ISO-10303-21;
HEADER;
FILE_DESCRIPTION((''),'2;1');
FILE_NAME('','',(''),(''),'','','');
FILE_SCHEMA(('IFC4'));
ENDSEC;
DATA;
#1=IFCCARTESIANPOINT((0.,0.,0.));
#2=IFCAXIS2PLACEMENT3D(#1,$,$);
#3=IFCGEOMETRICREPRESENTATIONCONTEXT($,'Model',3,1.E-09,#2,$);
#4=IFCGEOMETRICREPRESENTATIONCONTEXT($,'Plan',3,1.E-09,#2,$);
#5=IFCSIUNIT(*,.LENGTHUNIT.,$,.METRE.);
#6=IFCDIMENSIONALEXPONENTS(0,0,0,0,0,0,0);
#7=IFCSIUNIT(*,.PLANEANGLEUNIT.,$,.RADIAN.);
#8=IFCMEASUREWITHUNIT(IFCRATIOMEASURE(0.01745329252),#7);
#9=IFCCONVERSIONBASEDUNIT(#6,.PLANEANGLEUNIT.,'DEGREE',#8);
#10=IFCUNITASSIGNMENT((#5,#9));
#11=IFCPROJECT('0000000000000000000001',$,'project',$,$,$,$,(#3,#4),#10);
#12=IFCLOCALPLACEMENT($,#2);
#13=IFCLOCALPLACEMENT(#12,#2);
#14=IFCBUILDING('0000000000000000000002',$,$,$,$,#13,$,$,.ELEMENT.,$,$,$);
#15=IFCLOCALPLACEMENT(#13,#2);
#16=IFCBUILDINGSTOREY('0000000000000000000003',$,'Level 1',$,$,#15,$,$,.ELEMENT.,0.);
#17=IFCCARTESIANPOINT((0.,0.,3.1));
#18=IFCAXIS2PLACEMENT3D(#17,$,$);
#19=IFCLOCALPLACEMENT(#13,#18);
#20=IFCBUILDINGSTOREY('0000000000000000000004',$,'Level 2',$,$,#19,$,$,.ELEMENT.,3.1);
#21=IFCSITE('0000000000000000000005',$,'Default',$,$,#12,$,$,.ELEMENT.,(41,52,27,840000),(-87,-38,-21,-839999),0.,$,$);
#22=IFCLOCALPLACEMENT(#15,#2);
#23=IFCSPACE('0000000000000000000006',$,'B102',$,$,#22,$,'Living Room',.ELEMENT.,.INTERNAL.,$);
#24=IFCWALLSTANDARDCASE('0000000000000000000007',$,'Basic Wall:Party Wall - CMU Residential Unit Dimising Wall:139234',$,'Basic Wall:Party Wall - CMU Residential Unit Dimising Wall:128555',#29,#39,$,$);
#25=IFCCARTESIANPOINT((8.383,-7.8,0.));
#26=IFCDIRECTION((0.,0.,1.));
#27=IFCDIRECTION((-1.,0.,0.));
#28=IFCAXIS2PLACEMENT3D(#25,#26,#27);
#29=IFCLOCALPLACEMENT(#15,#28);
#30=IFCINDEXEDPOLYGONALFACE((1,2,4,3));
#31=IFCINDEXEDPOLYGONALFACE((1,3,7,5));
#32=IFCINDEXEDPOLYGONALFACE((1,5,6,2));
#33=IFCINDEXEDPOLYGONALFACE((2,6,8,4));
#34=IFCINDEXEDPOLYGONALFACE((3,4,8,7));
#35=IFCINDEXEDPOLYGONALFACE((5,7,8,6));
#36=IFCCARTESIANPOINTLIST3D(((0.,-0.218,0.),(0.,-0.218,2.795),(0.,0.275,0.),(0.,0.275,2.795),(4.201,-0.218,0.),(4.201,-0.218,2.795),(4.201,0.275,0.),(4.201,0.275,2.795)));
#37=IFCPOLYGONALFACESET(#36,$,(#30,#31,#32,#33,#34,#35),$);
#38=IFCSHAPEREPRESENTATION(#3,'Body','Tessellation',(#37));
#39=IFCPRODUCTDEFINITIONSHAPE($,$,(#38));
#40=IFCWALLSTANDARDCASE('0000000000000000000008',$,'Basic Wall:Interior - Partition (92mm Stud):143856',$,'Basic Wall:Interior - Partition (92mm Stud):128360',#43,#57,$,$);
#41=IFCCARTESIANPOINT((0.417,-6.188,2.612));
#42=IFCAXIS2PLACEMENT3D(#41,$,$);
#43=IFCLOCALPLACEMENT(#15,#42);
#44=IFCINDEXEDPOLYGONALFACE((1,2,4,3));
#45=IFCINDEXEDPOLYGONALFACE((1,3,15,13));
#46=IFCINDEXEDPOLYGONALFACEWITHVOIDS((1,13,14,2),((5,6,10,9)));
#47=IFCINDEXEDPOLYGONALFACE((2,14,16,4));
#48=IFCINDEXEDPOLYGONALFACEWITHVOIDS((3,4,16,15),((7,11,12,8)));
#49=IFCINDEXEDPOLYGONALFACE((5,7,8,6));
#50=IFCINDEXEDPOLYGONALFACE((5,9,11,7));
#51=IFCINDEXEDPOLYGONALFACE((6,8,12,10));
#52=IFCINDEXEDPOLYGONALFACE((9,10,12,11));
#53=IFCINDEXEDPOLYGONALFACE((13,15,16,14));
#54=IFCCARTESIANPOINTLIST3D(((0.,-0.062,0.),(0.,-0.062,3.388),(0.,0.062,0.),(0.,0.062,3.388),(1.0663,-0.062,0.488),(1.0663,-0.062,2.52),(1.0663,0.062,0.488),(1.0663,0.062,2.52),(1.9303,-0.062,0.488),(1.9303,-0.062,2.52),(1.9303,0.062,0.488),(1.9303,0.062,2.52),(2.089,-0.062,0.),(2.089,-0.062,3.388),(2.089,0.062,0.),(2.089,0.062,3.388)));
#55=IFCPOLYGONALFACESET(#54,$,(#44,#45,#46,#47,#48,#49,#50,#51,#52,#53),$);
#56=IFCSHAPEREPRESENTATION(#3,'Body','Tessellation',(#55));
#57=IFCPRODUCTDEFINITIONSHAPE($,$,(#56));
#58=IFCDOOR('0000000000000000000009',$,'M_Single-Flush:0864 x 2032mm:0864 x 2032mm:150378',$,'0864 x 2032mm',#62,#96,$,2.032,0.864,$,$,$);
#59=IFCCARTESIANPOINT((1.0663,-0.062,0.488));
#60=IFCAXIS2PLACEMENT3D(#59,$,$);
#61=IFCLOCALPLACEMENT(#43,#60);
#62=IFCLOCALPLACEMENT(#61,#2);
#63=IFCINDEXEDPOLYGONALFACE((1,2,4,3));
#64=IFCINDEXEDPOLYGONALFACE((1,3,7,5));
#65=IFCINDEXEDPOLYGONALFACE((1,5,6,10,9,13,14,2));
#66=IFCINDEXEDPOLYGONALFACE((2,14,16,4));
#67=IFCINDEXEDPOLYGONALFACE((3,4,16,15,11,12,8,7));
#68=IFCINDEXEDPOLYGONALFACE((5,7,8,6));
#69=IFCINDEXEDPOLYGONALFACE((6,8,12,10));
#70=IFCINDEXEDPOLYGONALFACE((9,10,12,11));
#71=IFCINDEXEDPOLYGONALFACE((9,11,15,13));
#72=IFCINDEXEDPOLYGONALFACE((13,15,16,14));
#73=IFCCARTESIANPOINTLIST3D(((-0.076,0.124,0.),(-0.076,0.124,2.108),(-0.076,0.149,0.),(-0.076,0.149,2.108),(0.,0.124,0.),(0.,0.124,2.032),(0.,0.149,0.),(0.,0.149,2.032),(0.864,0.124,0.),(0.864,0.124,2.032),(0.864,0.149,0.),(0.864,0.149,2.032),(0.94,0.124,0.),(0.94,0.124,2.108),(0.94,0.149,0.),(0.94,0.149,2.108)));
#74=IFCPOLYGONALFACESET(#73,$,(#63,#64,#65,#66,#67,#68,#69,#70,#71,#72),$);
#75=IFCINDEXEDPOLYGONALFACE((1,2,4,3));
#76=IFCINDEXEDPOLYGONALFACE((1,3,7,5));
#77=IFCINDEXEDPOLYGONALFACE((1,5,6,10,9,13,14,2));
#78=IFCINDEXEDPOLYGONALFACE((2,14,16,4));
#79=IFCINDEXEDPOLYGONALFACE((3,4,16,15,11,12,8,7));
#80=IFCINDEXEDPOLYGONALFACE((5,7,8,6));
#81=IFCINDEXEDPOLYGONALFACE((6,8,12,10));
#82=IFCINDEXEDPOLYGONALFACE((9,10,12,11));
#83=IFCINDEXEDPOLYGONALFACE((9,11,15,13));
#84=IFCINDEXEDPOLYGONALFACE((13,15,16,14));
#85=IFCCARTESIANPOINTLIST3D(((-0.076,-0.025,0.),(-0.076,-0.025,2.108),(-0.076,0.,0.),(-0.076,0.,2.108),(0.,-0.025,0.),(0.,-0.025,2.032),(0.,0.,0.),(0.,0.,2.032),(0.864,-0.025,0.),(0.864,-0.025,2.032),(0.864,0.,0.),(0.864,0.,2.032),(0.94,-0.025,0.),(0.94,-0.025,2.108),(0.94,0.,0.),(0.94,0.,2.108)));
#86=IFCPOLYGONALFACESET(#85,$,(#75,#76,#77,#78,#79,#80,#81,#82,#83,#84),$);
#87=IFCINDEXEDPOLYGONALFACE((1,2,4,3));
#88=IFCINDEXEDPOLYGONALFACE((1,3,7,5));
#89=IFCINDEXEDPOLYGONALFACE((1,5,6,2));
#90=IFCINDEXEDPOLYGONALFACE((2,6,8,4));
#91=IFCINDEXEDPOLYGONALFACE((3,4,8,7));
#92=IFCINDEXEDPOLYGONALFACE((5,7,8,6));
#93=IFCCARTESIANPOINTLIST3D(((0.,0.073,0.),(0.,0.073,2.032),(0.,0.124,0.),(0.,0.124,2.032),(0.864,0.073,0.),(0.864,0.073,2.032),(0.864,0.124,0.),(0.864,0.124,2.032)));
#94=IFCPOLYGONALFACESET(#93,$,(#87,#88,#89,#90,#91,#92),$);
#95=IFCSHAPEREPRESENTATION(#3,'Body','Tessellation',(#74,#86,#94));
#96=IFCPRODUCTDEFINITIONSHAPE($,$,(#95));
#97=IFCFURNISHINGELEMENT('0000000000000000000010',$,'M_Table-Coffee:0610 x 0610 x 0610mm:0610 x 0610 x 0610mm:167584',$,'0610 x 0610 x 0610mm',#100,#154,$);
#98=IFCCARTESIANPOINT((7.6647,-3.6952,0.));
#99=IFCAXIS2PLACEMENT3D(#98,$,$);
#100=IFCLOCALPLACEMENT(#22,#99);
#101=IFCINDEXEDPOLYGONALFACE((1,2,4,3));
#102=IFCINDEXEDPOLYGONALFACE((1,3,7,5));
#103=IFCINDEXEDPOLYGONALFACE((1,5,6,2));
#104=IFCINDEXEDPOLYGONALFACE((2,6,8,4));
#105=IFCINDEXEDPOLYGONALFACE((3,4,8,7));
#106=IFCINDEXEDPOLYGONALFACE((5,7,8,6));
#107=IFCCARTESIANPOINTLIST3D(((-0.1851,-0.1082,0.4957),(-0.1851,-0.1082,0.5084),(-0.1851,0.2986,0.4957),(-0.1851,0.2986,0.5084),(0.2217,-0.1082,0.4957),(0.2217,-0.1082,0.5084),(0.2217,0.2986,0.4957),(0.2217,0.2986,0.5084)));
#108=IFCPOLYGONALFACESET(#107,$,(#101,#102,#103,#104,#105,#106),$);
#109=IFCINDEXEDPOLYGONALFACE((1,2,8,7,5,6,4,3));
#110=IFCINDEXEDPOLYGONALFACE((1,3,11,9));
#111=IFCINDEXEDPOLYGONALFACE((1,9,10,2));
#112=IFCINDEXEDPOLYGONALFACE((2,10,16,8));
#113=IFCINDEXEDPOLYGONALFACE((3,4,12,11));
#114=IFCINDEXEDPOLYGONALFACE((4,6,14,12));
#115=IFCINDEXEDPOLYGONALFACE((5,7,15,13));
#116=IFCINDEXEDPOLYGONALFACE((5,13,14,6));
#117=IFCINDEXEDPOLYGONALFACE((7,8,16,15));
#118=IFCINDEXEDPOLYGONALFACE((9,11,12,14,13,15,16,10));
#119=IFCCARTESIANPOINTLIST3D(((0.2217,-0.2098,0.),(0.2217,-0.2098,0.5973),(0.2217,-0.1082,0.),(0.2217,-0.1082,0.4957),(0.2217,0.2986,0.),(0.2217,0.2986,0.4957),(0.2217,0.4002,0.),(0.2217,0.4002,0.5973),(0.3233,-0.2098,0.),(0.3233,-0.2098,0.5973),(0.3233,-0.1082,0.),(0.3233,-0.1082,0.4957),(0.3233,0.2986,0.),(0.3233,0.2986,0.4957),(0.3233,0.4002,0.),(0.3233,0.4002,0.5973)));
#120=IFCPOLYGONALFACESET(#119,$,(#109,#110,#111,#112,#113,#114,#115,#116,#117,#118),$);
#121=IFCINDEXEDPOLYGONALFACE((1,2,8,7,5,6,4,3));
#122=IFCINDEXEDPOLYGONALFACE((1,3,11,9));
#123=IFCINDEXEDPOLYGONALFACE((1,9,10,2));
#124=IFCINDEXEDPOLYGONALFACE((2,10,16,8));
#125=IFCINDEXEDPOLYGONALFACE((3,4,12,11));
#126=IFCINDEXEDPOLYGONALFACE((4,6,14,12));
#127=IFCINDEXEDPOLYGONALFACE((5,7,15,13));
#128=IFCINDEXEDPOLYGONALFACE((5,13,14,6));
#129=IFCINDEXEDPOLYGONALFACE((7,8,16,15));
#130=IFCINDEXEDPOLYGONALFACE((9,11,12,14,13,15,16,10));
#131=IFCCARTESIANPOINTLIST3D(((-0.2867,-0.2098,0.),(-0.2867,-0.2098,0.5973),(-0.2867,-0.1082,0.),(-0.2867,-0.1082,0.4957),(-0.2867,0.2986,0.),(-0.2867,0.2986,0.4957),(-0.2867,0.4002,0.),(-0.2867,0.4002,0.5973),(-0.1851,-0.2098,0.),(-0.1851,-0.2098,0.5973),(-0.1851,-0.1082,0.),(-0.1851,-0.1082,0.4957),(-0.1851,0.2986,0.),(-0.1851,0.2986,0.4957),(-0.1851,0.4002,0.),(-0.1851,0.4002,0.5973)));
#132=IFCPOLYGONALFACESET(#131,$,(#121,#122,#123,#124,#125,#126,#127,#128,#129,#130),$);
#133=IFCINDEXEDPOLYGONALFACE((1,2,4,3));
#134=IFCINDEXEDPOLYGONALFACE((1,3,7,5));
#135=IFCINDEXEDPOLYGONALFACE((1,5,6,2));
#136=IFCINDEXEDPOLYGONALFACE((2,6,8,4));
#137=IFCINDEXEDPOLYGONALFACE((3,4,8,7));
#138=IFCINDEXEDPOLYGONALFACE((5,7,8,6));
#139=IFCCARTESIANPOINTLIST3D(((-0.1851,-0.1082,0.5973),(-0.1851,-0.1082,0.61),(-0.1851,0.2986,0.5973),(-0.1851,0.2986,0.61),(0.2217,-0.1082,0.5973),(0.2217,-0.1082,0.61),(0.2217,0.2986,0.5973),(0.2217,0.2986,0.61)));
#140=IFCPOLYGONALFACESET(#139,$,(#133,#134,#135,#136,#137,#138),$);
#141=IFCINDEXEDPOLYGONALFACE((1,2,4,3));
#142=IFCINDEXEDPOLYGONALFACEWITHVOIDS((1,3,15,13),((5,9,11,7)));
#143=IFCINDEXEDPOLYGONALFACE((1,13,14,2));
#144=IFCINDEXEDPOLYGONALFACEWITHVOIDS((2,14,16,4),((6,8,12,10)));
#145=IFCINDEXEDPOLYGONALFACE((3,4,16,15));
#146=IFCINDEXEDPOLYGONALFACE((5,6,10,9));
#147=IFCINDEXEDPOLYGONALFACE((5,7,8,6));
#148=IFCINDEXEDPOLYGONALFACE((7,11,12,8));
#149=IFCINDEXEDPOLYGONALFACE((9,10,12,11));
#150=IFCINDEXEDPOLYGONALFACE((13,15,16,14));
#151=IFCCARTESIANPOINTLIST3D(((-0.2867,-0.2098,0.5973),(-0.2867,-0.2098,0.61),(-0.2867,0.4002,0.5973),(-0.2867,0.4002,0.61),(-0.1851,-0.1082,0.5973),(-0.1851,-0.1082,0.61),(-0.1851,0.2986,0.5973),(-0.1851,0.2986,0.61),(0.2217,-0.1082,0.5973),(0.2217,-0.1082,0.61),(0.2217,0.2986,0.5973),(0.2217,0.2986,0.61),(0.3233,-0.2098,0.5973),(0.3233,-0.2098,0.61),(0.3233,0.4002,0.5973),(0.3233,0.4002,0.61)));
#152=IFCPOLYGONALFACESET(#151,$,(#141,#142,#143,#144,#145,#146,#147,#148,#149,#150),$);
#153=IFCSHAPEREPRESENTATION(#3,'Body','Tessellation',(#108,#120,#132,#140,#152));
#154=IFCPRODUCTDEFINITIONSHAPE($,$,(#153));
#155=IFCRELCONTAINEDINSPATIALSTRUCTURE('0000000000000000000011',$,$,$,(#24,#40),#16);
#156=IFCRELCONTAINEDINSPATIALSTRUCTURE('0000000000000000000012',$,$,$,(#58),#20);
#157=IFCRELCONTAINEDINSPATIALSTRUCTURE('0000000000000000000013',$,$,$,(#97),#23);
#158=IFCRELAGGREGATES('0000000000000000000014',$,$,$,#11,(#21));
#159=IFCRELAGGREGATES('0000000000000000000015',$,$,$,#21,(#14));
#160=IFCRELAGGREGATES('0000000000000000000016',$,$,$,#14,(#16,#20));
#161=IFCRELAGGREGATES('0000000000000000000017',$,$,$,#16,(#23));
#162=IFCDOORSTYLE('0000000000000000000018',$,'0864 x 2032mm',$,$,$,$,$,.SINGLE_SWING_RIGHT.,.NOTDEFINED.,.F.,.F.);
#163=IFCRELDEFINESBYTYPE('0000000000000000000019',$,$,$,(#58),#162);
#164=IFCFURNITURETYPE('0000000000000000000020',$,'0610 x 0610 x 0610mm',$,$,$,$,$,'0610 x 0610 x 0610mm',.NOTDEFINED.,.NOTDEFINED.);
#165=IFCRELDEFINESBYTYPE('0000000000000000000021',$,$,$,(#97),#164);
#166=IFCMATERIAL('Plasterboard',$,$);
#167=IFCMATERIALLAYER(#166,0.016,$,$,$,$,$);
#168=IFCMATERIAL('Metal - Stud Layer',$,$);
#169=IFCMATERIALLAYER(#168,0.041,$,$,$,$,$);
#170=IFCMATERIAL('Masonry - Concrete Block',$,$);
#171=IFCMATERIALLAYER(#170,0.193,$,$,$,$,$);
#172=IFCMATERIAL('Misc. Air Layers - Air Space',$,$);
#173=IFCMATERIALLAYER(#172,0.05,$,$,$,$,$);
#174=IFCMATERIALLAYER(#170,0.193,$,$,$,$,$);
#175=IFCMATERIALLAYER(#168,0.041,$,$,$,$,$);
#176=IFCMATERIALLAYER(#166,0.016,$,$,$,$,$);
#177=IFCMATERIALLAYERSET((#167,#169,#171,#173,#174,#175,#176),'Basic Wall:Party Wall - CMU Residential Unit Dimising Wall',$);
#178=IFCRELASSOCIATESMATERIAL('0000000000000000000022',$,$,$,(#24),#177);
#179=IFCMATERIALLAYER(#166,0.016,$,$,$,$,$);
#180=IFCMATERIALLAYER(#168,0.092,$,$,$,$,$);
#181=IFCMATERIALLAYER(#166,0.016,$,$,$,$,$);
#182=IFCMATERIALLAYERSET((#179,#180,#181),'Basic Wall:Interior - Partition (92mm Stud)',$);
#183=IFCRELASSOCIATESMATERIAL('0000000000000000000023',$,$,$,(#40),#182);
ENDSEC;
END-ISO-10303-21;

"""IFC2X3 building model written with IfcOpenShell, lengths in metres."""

from ifc_helpers import new_model, entity, si_unit, converted_unit, frame, frame_2d, origin, origin_2d_with_axis, place, context, project, spatial, polyline, rectangle, outline, extrude, clip, bounded_halfspace, source, transform, mapped, material, layer, layer_set, layer_usage, type_object, type_shapes, element, fill, save


model = new_model("IFC2X3")

# Units and contexts
model_context = context("Model", 3, precision=1e-09, world=origin())
plan_context = context("Plan", 3, precision=1e-09, world=origin())
ifc_project = project(units=[si_unit("LENGTHUNIT", "METRE"), converted_unit("PLANEANGLEUNIT", "DEGREE", entity("IfcRatioMeasure", 0.01745329252), si_unit("PLANEANGLEUNIT", "RADIAN"), dimensions=[0, 0, 0, 0, 0, 0, 0])], contexts=[model_context, plan_context])

# Site, building, storey
site_placement = place(None, origin())
site = spatial("IfcSite", under=ifc_project, at=site_placement, Name="Default", CompositionType="ELEMENT", RefLatitude=(41, 52, 27, 840000), RefLongitude=(-87, -38, -21, -839999), RefElevation=0.0)
building_placement = place(site_placement, origin())
building = spatial("IfcBuilding", under=site, at=building_placement, CompositionType="ELEMENT")
storey_1_placement = place(building_placement, origin())
storey_1 = spatial("IfcBuildingStorey", under=building, at=storey_1_placement, Name="Level 1", CompositionType="ELEMENT", Elevation=0.0)

# Shared definitions
ifc_material_1 = material(Name="Misc. Air Layers - Air Space")
ifc_material_2 = material(Name="Masonry - Concrete Block")
ifc_material_3 = material(Name="Metal - Stud Layer")
ifc_material_4 = material(Name="Plasterboard")

# Shared definitions
ifc_layer_1 = layer(ifc_material_4, 0.016)
ifc_layer_2 = layer(ifc_material_3, 0.092)
ifc_layer_3 = layer(ifc_material_4, 0.016)
ifc_layer_set_1 = layer_set([ifc_layer_1, ifc_layer_2, ifc_layer_3], Name="Basic Wall:Interior - Partition (92mm Stud)")

# Wall
ifc_layer_4 = layer(ifc_material_4, 0.016)
ifc_layer_5 = layer(ifc_material_3, 0.041)
ifc_layer_6 = layer(ifc_material_2, 0.193)
ifc_layer_7 = layer(ifc_material_1, 0.05)
ifc_layer_8 = layer(ifc_material_2, 0.193)
ifc_layer_9 = layer(ifc_material_3, 0.041)
ifc_layer_10 = layer(ifc_material_4, 0.016)
ifc_layer_set_2 = layer_set([ifc_layer_4, ifc_layer_5, ifc_layer_6, ifc_layer_7, ifc_layer_8, ifc_layer_9, ifc_layer_10], Name="Basic Wall:Party Wall - CMU Residential Unit Dimising Wall")
ifc_layer_usage_1 = layer_usage(ifc_layer_set_2, "AXIS2", "NEGATIVE", 0.275)
wall_1_placement = place(storey_1_placement, frame((8.383, -7.8, 0.0), z_axis=(0.0, 0.0, 1.0), x_axis=(-1.0, 0.0, 0.0)))
element("IfcWallStandardCase", 1, at=wall_1_placement, inside=storey_1, material=ifc_layer_usage_1, Name="Basic Wall:Party Wall - CMU Residential Unit Dimising Wall:139234", ObjectType="Basic Wall:Party Wall - CMU Residential Unit Dimising Wall:128555", context=model_context, shape_type="Clipping", body=[
    clip(clip(extrude(rectangle(XDim=4.201, YDim=0.55, at=frame_2d((2.1005, 0.0), x_axis=(-1.0, 0.0))), origin(), (0.0, 0.0, 1.0), 2.795), bounded_halfspace(frame((0.0, -0.218, 2.795), z_axis=(0.0, 1.0, 0.0), x_axis=(-1.0, 0.0, 0.0)), True, frame((0.0, -0.218, 2.795), z_axis=(0.0, 1.0, 0.0), x_axis=(-1.0, 0.0, 0.0)), polyline([(0.0, 0.0), (-3.708, 0.0), (-4.201, 0.0), (-4.201, -2.795), (0.0, -2.795), (0.0, 0.0)]))), bounded_halfspace(frame((4.201, 0.275, 0.0), z_axis=(-1.0, 0.0, 0.0), x_axis=(0.0, -1.0, 0.0)), True, frame((4.201, 0.275, 0.0), z_axis=(-1.0, 0.0, 0.0), x_axis=(0.0, -1.0, 0.0)), polyline([(0.0, 0.0), (0.493, 0.0), (0.493, 2.795), (0.0, 2.795), (0.0, 0.0)]))),
])

# Wall, opening
ifc_layer_usage_2 = layer_usage(ifc_layer_set_1, "AXIS2", "NEGATIVE", 0.062)
wall_2_placement = place(storey_1_placement, frame((0.417, -6.188, 2.612)))
wall_2 = element("IfcWallStandardCase", 2, at=wall_2_placement, inside=storey_1, material=ifc_layer_usage_2, Name="Basic Wall:Interior - Partition (92mm Stud):143856", ObjectType="Basic Wall:Interior - Partition (92mm Stud):128360", context=model_context, shape_type="SweptSolid", body=[
    extrude(rectangle(XDim=2.089, YDim=0.124, at=frame_2d((1.0445, 0.0), x_axis=(-1.0, 0.0))), origin(), (0.0, 0.0, 1.0), 3.388),
])
opening_1_placement = place(wall_2_placement, frame((1.0663, -0.062, 0.488)))
opening_1 = element("IfcOpeningElement", 3, at=opening_1_placement, cuts=wall_2, ObjectType="Opening", context=model_context, shape_type="SweptSolid", body=[
    extrude(rectangle(XDim=0.864, YDim=2.032, at=frame_2d((1.016, 0.432), x_axis=(0.0, 1.0))), frame((0.0, 0.0, 0.0), z_axis=(0.0, 1.0, 0.0), x_axis=(0.0, 0.0, 1.0)), (0.0, 0.0, 1.0), 0.124),
])

# Shared definitions
storey_2_placement = place(building_placement, frame((0.0, 0.0, 3.1)))
storey_2 = spatial("IfcBuildingStorey", under=building, at=storey_2_placement, Name="Level 2", CompositionType="ELEMENT", Elevation=3.1)

# Door
door_style_1 = type_object("IfcDoorStyle", Name="0864 x 2032mm", ConstructionType="NOTDEFINED", OperationType="SINGLE_SWING_RIGHT", ParameterTakesPrecedence=False, Sizeable=False)
shared_shape_1 = source(origin(), model_context, "Body", "SweptSolid", [
    extrude(outline(polyline([(-0.508, -1.073), (0.508, -1.073), (0.508, 1.035), (0.432, 1.035), (0.432, -0.997), (-0.432, -0.997), (-0.432, 1.035), (-0.508, 1.035), (-0.508, -1.073)])), frame((0.432, 0.124, 1.035), z_axis=(0.0, 1.0, 0.0), x_axis=(1.0, 0.0, 0.0)), (0.0, 0.0, 1.0), 0.025),
    extrude(outline(polyline([(-1.073, -0.508), (1.035, -0.508), (1.035, -0.432), (-0.997, -0.432), (-0.997, 0.432), (1.035, 0.432), (1.035, 0.508), (-1.073, 0.508), (-1.073, -0.508)])), frame((0.432, -0.025, 1.035), z_axis=(0.0, 1.0, 0.0), x_axis=(0.0, 0.0, -1.0)), (0.0, 0.0, 1.0), 0.025),
    extrude(rectangle(XDim=0.051, YDim=0.864, at=origin_2d_with_axis()), frame((0.432, 0.0985, 0.0), z_axis=(0.0, 0.0, 1.0), x_axis=(0.0, 1.0, 0.0)), (0.0, 0.0, 1.0), 2.032),
])
type_shapes(door_style_1, [shared_shape_1])
door_1_placement = place(opening_1_placement, origin())
door_1 = element("IfcDoor", 4, at=door_1_placement, inside=storey_2, type_object=door_style_1, Name="M_Single-Flush:0864 x 2032mm:0864 x 2032mm:150378", ObjectType="0864 x 2032mm", OverallHeight=2.032, OverallWidth=0.864, context=model_context, shape_type="MappedRepresentation", body=[
    mapped(shared_shape_1, transform((0.0, 0.0, 0.0), scale=1.0)),
])
fill(opening_1, door_1)

# Shared definitions
space_1_placement = place(storey_1_placement, origin())
space_1 = spatial("IfcSpace", under=storey_1, at=space_1_placement, Name="B102", LongName="Living Room", CompositionType="ELEMENT", InteriorOrExteriorSpace="INTERNAL")

# Furnishing element
furniture_type_1 = type_object("IfcFurnitureType", Name="0610 x 0610 x 0610mm", ElementType="0610 x 0610 x 0610mm", AssemblyPlace="NOTDEFINED")
shared_shape_2 = source(origin(), model_context, "Body", "SweptSolid", [
    extrude(rectangle(XDim=0.4068, YDim=0.4068, at=origin_2d_with_axis()), frame((0.0183, 0.0952, 0.4957), z_axis=(0.0, 0.0, 1.0), x_axis=(-1.0, 0.0, 0.0)), (0.0, 0.0, 1.0), 0.0127),
    extrude(outline(polyline([(-0.2732, -0.305), (0.3241, -0.305), (0.3241, 0.305), (-0.2732, 0.305), (-0.2732, 0.2034), (0.2225, 0.2034), (0.2225, -0.2034), (-0.2732, -0.2034), (-0.2732, -0.305)])), frame((0.2217, 0.0952, 0.2732), z_axis=(1.0, 0.0, 0.0), x_axis=(0.0, 0.0, 1.0)), (0.0, 0.0, 1.0), 0.1016),
    extrude(outline(polyline([(-0.305, -0.3241), (0.305, -0.3241), (0.305, 0.2732), (0.2034, 0.2732), (0.2034, -0.2225), (-0.2034, -0.2225), (-0.2034, 0.2732), (-0.305, 0.2732), (-0.305, -0.3241)])), frame((-0.2867, 0.0952, 0.2732), z_axis=(1.0, 0.0, 0.0), x_axis=(0.0, -1.0, 0.0)), (0.0, 0.0, 1.0), 0.1016),
    extrude(rectangle(XDim=0.4068, YDim=0.4068, at=origin_2d_with_axis()), frame((0.0183, 0.0952, 0.5973), z_axis=(0.0, 0.0, 1.0), x_axis=(-1.0, 0.0, 0.0)), (0.0, 0.0, 1.0), 0.0127),
    extrude(outline(polyline([(-0.305, -0.305), (0.305, -0.305), (0.305, 0.305), (-0.305, 0.305), (-0.305, -0.305)]), holes=[polyline([(-0.2034, -0.2034), (-0.2034, 0.2034), (0.2034, 0.2034), (0.2034, -0.2034), (-0.2034, -0.2034)])]), frame((0.0183, 0.0952, 0.5973), z_axis=(0.0, 0.0, 1.0), x_axis=(-1.0, 0.0, 0.0)), (0.0, 0.0, 1.0), 0.0127),
])
type_shapes(furniture_type_1, [shared_shape_2])
for number, where, name in (
    (5, (7.6647, -3.6952, 0.0), "M_Table-Coffee:0610 x 0610 x 0610mm:0610 x 0610 x 0610mm:167584"),
):
    element("IfcFurnishingElement", number, at=place(space_1_placement, frame(where)), inside=space_1, type_object=furniture_type_1, Name=name, ObjectType="0610 x 0610 x 0610mm", context=model_context, shape_type="MappedRepresentation", body=[
        mapped(shared_shape_2, transform((0.0, 0.0, 0.0), scale=1.0)),
    ])

save(model, "model.ifc")
